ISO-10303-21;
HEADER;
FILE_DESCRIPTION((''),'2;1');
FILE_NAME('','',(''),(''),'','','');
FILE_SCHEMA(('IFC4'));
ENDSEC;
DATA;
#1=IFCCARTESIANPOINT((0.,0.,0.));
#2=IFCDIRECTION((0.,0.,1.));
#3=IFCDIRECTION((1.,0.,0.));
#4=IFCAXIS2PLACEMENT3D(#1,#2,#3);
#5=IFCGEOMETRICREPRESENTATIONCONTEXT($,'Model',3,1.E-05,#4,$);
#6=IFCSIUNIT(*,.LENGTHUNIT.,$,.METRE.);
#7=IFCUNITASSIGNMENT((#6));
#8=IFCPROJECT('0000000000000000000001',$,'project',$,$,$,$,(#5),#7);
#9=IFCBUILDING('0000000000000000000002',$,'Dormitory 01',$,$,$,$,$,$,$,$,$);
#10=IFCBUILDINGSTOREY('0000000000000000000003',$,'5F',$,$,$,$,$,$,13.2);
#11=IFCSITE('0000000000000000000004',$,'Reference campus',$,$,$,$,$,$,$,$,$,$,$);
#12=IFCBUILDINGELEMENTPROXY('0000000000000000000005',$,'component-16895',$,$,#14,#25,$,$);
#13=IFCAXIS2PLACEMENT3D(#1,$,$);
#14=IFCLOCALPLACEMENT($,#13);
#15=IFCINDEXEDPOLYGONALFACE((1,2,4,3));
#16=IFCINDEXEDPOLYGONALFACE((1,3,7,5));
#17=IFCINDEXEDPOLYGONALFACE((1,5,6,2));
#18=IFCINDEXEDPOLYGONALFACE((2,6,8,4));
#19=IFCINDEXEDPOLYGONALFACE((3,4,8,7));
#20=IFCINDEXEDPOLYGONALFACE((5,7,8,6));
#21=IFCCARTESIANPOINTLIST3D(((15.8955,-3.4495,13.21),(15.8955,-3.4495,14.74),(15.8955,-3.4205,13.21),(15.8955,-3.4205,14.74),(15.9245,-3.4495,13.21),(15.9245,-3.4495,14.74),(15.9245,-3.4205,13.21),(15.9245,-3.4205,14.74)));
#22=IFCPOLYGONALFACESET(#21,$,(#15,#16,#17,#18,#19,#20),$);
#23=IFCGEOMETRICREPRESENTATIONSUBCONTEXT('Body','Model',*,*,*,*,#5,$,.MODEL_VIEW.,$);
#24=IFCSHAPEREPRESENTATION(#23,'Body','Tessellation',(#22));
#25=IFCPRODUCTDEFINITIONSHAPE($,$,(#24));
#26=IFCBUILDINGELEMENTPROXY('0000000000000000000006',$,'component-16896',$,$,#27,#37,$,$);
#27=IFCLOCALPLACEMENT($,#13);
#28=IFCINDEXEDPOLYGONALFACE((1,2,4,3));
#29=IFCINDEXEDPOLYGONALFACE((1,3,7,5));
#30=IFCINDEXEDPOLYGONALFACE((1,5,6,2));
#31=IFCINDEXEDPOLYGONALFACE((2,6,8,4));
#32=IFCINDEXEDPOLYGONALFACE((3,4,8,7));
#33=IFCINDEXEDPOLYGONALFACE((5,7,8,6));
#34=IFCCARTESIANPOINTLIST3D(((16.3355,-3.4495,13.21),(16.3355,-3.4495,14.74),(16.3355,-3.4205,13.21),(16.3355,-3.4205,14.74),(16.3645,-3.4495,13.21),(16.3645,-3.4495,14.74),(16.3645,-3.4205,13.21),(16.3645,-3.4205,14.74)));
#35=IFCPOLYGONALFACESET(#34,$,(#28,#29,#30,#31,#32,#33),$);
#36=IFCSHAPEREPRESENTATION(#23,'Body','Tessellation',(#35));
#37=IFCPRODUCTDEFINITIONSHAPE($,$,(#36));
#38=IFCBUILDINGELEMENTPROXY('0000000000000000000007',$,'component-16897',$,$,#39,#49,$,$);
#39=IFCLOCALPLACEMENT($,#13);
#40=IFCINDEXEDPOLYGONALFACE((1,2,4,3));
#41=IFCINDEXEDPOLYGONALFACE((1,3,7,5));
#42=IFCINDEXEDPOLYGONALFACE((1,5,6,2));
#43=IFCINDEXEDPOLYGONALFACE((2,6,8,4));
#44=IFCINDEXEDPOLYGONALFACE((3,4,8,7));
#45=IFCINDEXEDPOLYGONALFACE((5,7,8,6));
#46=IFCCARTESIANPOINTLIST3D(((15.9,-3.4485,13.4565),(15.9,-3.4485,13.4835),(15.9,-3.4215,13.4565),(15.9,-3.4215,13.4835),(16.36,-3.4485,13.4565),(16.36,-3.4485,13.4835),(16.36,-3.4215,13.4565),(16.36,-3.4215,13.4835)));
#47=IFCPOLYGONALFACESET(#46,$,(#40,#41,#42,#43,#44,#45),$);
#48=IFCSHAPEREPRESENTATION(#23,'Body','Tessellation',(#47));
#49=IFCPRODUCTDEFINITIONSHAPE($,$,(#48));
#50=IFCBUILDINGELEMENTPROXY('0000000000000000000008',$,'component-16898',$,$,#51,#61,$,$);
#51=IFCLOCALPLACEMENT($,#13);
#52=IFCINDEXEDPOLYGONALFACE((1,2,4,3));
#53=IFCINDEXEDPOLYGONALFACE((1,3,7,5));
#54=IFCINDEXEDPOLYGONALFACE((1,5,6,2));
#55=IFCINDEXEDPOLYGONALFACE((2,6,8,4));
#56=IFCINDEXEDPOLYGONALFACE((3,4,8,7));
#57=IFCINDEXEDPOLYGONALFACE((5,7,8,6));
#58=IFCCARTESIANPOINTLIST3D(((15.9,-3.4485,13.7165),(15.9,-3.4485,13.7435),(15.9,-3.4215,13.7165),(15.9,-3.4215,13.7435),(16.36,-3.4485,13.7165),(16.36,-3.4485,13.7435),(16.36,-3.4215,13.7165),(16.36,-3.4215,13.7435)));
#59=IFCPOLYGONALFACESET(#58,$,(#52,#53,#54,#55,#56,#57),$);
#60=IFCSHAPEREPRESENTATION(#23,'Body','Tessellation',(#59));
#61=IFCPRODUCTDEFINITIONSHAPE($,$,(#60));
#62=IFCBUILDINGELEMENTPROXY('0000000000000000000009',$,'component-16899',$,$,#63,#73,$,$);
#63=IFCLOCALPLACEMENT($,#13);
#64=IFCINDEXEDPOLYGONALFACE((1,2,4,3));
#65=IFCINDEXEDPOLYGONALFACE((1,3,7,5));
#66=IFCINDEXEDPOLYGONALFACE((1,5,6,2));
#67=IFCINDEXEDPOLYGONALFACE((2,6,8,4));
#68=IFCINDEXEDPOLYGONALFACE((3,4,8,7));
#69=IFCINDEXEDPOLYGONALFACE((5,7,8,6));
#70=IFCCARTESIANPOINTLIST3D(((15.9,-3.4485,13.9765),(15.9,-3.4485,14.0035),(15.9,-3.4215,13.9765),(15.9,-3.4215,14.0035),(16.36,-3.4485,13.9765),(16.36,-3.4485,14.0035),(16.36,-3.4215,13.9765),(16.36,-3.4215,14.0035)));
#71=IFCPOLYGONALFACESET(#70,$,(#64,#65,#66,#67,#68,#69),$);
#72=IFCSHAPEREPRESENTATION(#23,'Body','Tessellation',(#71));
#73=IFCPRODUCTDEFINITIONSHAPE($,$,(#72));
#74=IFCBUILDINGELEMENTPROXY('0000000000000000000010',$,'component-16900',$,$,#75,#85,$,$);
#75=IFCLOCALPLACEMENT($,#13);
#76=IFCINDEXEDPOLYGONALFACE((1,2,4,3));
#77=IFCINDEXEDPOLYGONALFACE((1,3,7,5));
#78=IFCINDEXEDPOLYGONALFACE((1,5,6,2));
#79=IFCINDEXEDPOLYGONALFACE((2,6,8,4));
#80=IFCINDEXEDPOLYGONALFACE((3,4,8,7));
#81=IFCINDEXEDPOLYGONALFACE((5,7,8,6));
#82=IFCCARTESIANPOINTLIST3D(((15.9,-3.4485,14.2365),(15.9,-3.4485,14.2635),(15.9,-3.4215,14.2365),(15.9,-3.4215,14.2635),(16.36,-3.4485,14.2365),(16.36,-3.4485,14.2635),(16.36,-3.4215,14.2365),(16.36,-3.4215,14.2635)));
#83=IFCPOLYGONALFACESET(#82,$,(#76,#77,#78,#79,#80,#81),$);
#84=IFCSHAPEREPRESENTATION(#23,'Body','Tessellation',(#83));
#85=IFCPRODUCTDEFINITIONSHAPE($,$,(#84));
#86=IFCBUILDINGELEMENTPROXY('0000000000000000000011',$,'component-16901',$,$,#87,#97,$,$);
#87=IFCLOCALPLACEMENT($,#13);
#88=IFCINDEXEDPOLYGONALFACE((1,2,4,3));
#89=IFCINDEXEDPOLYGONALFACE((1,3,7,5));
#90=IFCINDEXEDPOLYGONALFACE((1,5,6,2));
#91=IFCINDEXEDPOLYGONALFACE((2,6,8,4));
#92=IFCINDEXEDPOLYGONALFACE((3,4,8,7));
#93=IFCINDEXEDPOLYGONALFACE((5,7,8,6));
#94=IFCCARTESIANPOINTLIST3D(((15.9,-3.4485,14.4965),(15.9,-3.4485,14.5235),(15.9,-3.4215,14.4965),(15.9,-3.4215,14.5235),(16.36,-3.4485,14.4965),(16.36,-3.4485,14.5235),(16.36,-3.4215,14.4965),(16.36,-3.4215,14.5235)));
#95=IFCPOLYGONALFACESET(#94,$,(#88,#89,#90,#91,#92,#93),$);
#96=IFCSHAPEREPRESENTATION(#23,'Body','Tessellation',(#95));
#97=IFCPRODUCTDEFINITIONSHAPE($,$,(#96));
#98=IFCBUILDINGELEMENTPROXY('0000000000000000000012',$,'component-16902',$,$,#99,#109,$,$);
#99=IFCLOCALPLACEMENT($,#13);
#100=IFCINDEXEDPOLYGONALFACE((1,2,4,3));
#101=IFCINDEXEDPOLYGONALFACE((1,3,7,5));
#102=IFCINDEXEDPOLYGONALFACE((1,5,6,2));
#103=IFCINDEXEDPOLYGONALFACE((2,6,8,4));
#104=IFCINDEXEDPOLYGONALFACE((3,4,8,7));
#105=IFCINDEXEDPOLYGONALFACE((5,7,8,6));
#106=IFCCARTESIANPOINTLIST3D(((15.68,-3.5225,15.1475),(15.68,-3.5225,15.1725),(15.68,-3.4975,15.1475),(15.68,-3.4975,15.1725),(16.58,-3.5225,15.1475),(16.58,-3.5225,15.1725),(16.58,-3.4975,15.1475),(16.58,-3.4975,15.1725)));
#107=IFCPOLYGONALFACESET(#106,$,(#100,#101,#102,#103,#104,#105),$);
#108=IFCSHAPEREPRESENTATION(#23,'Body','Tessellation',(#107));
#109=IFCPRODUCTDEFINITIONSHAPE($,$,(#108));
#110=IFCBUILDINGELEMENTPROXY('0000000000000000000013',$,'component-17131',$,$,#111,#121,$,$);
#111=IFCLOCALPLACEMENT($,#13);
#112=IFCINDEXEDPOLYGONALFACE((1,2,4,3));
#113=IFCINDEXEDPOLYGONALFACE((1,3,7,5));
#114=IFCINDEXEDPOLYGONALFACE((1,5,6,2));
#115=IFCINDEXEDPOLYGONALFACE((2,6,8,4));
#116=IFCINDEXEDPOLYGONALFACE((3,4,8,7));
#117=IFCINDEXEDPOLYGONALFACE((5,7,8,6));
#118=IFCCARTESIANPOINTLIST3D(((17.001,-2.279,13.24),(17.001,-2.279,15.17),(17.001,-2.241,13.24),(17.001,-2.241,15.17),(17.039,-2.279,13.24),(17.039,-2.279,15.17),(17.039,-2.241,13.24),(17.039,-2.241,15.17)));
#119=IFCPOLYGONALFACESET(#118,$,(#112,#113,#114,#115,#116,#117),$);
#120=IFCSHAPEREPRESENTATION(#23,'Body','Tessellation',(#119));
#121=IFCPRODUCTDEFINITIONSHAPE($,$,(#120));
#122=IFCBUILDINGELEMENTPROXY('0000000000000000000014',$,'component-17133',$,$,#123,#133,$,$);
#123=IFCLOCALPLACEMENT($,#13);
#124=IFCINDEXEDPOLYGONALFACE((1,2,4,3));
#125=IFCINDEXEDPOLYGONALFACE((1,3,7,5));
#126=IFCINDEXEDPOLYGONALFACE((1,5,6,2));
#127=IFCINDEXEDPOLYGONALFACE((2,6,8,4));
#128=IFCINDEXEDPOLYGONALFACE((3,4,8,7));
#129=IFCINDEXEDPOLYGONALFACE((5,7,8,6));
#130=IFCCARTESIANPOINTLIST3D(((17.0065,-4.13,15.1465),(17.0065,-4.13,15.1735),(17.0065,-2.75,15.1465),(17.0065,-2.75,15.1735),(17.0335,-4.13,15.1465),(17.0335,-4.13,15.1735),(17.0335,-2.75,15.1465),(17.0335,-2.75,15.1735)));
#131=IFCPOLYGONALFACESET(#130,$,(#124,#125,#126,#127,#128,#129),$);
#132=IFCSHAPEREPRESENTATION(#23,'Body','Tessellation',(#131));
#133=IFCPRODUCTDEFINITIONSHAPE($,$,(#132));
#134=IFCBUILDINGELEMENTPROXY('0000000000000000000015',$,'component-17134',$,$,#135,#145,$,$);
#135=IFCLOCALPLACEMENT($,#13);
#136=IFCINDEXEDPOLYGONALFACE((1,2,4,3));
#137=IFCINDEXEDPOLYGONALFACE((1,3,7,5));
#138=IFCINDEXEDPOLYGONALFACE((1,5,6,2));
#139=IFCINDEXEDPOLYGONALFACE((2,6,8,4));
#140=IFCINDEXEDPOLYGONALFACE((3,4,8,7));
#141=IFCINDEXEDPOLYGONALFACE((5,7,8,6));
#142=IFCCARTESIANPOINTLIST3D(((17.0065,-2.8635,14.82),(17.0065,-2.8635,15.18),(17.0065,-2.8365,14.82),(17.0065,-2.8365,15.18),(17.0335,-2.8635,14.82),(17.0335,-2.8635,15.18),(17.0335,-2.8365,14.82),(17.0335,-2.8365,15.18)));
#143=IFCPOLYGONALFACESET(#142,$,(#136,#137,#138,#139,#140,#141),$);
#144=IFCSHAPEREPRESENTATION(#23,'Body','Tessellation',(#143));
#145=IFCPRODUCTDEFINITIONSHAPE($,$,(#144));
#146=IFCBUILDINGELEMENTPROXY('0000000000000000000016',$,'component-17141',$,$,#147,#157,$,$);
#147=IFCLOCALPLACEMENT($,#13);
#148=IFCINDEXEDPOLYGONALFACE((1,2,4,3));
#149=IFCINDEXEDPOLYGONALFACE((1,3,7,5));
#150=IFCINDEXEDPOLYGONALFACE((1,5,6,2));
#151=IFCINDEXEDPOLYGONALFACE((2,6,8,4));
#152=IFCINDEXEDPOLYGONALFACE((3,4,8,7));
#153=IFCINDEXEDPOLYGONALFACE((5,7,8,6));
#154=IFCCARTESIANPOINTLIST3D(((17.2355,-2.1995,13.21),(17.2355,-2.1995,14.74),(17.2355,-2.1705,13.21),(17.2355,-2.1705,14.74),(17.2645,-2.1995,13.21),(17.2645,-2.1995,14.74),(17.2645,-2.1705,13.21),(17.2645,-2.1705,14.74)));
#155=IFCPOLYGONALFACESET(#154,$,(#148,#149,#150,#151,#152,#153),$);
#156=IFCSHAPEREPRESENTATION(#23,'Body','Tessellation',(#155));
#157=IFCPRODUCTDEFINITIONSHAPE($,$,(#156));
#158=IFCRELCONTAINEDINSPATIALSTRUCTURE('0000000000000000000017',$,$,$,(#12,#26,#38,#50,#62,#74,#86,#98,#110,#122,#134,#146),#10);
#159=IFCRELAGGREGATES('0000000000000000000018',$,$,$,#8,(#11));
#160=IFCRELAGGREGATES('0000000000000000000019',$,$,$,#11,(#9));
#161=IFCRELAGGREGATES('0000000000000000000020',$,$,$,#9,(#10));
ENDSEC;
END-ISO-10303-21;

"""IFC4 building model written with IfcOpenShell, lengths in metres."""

from ifc_helpers import new_model, si_unit, frame, origin, origin_with_axes, origin_2d, place, context, subcontext, project, spatial, rectangle, extrude, element, save


model = new_model("IFC4")

# Units and contexts
model_context = context("Model", 3, precision=1e-05, world=origin_with_axes())
body_context = subcontext(model_context, "Body", "Model", "MODEL_VIEW")
ifc_project = project(units=[si_unit("LENGTHUNIT", "METRE")], contexts=[model_context])

# Site, building, storey
site = spatial("IfcSite", under=ifc_project, Name="Reference campus")
building = spatial("IfcBuilding", under=site, Name="Dormitory 01")
storey = spatial("IfcBuildingStorey", under=building, Name="5F", Elevation=13.2)

# Building element proxies
for number, where, z_axis, x_axis, name in (
    (1, (15.91, -3.435, 13.21), (0.0, 0.0, 1.0), (1.0, 0.0, 0.0), "component-16895"),
    (2, (16.35, -3.435, 13.21), (0.0, 0.0, 1.0), (1.0, 0.0, 0.0), "component-16896"),
):
    element("IfcBuildingElementProxy", number, at=place(None, frame(where, z_axis=z_axis, x_axis=x_axis)), inside=storey, Name=name, context=body_context, shape_type="SweptSolid", body=[
        extrude(rectangle(XDim=0.029, YDim=0.029, at=origin_2d()), origin(), (0.0, 0.0, 1.0), 1.53),
    ])
for number, where, z_axis, x_axis, name in (
    (3, (16.13, -3.435, 13.4565), (0.0, 0.0, 1.0), (1.0, 0.0, 0.0), "component-16897"),
    (4, (16.13, -3.435, 13.7165), (0.0, 0.0, 1.0), (1.0, 0.0, 0.0), "component-16898"),
    (5, (16.13, -3.435, 13.9765), (0.0, 0.0, 1.0), (1.0, 0.0, 0.0), "component-16899"),
    (6, (16.13, -3.435, 14.2365), (0.0, 0.0, 1.0), (1.0, 0.0, 0.0), "component-16900"),
    (7, (16.13, -3.435, 14.4965), (0.0, 0.0, 1.0), (1.0, 0.0, 0.0), "component-16901"),
):
    element("IfcBuildingElementProxy", number, at=place(None, frame(where, z_axis=z_axis, x_axis=x_axis)), inside=storey, Name=name, context=body_context, shape_type="SweptSolid", body=[
        extrude(rectangle(XDim=0.46, YDim=0.027, at=origin_2d()), origin(), (0.0, 0.0, 1.0), 0.027),
    ])
proxy_1_placement = place(None, frame((16.13, -3.51, 15.1475), z_axis=(0.0, 0.0, 1.0), x_axis=(1.0, 0.0, 0.0)))
element("IfcBuildingElementProxy", 8, at=proxy_1_placement, inside=storey, Name="component-16902", context=body_context, shape_type="SweptSolid", body=[
    extrude(rectangle(XDim=0.9, YDim=0.025, at=origin_2d()), origin(), (0.0, 0.0, 1.0), 0.025),
])
proxy_2_placement = place(None, frame((17.02, -2.26, 13.24), z_axis=(0.0, 0.0, 1.0), x_axis=(1.0, 0.0, 0.0)))
element("IfcBuildingElementProxy", 9, at=proxy_2_placement, inside=storey, Name="component-17131", context=body_context, shape_type="SweptSolid", body=[
    extrude(rectangle(XDim=0.038, YDim=0.038, at=origin_2d()), origin(), (0.0, 0.0, 1.0), 1.93),
])
proxy_3_placement = place(None, frame((17.02, -3.44, 15.1465), z_axis=(0.0, 0.0, 1.0), x_axis=(1.0, 0.0, 0.0)))
element("IfcBuildingElementProxy", 10, at=proxy_3_placement, inside=storey, Name="component-17133", context=body_context, shape_type="SweptSolid", body=[
    extrude(rectangle(XDim=0.027, YDim=1.38, at=origin_2d()), origin(), (0.0, 0.0, 1.0), 0.027),
])
proxy_4_placement = place(None, frame((17.02, -2.85, 14.82), z_axis=(0.0, 0.0, 1.0), x_axis=(1.0, 0.0, 0.0)))
element("IfcBuildingElementProxy", 11, at=proxy_4_placement, inside=storey, Name="component-17134", context=body_context, shape_type="SweptSolid", body=[
    extrude(rectangle(XDim=0.027, YDim=0.027, at=origin_2d()), origin(), (0.0, 0.0, 1.0), 0.36),
])
proxy_5_placement = place(None, frame((17.25, -2.185, 13.21), z_axis=(0.0, 0.0, 1.0), x_axis=(1.0, 0.0, 0.0)))
element("IfcBuildingElementProxy", 12, at=proxy_5_placement, inside=storey, Name="component-17141", context=body_context, shape_type="SweptSolid", body=[
    extrude(rectangle(XDim=0.029, YDim=0.029, at=origin_2d()), origin(), (0.0, 0.0, 1.0), 1.53),
])

save(model, "model.ifc")
